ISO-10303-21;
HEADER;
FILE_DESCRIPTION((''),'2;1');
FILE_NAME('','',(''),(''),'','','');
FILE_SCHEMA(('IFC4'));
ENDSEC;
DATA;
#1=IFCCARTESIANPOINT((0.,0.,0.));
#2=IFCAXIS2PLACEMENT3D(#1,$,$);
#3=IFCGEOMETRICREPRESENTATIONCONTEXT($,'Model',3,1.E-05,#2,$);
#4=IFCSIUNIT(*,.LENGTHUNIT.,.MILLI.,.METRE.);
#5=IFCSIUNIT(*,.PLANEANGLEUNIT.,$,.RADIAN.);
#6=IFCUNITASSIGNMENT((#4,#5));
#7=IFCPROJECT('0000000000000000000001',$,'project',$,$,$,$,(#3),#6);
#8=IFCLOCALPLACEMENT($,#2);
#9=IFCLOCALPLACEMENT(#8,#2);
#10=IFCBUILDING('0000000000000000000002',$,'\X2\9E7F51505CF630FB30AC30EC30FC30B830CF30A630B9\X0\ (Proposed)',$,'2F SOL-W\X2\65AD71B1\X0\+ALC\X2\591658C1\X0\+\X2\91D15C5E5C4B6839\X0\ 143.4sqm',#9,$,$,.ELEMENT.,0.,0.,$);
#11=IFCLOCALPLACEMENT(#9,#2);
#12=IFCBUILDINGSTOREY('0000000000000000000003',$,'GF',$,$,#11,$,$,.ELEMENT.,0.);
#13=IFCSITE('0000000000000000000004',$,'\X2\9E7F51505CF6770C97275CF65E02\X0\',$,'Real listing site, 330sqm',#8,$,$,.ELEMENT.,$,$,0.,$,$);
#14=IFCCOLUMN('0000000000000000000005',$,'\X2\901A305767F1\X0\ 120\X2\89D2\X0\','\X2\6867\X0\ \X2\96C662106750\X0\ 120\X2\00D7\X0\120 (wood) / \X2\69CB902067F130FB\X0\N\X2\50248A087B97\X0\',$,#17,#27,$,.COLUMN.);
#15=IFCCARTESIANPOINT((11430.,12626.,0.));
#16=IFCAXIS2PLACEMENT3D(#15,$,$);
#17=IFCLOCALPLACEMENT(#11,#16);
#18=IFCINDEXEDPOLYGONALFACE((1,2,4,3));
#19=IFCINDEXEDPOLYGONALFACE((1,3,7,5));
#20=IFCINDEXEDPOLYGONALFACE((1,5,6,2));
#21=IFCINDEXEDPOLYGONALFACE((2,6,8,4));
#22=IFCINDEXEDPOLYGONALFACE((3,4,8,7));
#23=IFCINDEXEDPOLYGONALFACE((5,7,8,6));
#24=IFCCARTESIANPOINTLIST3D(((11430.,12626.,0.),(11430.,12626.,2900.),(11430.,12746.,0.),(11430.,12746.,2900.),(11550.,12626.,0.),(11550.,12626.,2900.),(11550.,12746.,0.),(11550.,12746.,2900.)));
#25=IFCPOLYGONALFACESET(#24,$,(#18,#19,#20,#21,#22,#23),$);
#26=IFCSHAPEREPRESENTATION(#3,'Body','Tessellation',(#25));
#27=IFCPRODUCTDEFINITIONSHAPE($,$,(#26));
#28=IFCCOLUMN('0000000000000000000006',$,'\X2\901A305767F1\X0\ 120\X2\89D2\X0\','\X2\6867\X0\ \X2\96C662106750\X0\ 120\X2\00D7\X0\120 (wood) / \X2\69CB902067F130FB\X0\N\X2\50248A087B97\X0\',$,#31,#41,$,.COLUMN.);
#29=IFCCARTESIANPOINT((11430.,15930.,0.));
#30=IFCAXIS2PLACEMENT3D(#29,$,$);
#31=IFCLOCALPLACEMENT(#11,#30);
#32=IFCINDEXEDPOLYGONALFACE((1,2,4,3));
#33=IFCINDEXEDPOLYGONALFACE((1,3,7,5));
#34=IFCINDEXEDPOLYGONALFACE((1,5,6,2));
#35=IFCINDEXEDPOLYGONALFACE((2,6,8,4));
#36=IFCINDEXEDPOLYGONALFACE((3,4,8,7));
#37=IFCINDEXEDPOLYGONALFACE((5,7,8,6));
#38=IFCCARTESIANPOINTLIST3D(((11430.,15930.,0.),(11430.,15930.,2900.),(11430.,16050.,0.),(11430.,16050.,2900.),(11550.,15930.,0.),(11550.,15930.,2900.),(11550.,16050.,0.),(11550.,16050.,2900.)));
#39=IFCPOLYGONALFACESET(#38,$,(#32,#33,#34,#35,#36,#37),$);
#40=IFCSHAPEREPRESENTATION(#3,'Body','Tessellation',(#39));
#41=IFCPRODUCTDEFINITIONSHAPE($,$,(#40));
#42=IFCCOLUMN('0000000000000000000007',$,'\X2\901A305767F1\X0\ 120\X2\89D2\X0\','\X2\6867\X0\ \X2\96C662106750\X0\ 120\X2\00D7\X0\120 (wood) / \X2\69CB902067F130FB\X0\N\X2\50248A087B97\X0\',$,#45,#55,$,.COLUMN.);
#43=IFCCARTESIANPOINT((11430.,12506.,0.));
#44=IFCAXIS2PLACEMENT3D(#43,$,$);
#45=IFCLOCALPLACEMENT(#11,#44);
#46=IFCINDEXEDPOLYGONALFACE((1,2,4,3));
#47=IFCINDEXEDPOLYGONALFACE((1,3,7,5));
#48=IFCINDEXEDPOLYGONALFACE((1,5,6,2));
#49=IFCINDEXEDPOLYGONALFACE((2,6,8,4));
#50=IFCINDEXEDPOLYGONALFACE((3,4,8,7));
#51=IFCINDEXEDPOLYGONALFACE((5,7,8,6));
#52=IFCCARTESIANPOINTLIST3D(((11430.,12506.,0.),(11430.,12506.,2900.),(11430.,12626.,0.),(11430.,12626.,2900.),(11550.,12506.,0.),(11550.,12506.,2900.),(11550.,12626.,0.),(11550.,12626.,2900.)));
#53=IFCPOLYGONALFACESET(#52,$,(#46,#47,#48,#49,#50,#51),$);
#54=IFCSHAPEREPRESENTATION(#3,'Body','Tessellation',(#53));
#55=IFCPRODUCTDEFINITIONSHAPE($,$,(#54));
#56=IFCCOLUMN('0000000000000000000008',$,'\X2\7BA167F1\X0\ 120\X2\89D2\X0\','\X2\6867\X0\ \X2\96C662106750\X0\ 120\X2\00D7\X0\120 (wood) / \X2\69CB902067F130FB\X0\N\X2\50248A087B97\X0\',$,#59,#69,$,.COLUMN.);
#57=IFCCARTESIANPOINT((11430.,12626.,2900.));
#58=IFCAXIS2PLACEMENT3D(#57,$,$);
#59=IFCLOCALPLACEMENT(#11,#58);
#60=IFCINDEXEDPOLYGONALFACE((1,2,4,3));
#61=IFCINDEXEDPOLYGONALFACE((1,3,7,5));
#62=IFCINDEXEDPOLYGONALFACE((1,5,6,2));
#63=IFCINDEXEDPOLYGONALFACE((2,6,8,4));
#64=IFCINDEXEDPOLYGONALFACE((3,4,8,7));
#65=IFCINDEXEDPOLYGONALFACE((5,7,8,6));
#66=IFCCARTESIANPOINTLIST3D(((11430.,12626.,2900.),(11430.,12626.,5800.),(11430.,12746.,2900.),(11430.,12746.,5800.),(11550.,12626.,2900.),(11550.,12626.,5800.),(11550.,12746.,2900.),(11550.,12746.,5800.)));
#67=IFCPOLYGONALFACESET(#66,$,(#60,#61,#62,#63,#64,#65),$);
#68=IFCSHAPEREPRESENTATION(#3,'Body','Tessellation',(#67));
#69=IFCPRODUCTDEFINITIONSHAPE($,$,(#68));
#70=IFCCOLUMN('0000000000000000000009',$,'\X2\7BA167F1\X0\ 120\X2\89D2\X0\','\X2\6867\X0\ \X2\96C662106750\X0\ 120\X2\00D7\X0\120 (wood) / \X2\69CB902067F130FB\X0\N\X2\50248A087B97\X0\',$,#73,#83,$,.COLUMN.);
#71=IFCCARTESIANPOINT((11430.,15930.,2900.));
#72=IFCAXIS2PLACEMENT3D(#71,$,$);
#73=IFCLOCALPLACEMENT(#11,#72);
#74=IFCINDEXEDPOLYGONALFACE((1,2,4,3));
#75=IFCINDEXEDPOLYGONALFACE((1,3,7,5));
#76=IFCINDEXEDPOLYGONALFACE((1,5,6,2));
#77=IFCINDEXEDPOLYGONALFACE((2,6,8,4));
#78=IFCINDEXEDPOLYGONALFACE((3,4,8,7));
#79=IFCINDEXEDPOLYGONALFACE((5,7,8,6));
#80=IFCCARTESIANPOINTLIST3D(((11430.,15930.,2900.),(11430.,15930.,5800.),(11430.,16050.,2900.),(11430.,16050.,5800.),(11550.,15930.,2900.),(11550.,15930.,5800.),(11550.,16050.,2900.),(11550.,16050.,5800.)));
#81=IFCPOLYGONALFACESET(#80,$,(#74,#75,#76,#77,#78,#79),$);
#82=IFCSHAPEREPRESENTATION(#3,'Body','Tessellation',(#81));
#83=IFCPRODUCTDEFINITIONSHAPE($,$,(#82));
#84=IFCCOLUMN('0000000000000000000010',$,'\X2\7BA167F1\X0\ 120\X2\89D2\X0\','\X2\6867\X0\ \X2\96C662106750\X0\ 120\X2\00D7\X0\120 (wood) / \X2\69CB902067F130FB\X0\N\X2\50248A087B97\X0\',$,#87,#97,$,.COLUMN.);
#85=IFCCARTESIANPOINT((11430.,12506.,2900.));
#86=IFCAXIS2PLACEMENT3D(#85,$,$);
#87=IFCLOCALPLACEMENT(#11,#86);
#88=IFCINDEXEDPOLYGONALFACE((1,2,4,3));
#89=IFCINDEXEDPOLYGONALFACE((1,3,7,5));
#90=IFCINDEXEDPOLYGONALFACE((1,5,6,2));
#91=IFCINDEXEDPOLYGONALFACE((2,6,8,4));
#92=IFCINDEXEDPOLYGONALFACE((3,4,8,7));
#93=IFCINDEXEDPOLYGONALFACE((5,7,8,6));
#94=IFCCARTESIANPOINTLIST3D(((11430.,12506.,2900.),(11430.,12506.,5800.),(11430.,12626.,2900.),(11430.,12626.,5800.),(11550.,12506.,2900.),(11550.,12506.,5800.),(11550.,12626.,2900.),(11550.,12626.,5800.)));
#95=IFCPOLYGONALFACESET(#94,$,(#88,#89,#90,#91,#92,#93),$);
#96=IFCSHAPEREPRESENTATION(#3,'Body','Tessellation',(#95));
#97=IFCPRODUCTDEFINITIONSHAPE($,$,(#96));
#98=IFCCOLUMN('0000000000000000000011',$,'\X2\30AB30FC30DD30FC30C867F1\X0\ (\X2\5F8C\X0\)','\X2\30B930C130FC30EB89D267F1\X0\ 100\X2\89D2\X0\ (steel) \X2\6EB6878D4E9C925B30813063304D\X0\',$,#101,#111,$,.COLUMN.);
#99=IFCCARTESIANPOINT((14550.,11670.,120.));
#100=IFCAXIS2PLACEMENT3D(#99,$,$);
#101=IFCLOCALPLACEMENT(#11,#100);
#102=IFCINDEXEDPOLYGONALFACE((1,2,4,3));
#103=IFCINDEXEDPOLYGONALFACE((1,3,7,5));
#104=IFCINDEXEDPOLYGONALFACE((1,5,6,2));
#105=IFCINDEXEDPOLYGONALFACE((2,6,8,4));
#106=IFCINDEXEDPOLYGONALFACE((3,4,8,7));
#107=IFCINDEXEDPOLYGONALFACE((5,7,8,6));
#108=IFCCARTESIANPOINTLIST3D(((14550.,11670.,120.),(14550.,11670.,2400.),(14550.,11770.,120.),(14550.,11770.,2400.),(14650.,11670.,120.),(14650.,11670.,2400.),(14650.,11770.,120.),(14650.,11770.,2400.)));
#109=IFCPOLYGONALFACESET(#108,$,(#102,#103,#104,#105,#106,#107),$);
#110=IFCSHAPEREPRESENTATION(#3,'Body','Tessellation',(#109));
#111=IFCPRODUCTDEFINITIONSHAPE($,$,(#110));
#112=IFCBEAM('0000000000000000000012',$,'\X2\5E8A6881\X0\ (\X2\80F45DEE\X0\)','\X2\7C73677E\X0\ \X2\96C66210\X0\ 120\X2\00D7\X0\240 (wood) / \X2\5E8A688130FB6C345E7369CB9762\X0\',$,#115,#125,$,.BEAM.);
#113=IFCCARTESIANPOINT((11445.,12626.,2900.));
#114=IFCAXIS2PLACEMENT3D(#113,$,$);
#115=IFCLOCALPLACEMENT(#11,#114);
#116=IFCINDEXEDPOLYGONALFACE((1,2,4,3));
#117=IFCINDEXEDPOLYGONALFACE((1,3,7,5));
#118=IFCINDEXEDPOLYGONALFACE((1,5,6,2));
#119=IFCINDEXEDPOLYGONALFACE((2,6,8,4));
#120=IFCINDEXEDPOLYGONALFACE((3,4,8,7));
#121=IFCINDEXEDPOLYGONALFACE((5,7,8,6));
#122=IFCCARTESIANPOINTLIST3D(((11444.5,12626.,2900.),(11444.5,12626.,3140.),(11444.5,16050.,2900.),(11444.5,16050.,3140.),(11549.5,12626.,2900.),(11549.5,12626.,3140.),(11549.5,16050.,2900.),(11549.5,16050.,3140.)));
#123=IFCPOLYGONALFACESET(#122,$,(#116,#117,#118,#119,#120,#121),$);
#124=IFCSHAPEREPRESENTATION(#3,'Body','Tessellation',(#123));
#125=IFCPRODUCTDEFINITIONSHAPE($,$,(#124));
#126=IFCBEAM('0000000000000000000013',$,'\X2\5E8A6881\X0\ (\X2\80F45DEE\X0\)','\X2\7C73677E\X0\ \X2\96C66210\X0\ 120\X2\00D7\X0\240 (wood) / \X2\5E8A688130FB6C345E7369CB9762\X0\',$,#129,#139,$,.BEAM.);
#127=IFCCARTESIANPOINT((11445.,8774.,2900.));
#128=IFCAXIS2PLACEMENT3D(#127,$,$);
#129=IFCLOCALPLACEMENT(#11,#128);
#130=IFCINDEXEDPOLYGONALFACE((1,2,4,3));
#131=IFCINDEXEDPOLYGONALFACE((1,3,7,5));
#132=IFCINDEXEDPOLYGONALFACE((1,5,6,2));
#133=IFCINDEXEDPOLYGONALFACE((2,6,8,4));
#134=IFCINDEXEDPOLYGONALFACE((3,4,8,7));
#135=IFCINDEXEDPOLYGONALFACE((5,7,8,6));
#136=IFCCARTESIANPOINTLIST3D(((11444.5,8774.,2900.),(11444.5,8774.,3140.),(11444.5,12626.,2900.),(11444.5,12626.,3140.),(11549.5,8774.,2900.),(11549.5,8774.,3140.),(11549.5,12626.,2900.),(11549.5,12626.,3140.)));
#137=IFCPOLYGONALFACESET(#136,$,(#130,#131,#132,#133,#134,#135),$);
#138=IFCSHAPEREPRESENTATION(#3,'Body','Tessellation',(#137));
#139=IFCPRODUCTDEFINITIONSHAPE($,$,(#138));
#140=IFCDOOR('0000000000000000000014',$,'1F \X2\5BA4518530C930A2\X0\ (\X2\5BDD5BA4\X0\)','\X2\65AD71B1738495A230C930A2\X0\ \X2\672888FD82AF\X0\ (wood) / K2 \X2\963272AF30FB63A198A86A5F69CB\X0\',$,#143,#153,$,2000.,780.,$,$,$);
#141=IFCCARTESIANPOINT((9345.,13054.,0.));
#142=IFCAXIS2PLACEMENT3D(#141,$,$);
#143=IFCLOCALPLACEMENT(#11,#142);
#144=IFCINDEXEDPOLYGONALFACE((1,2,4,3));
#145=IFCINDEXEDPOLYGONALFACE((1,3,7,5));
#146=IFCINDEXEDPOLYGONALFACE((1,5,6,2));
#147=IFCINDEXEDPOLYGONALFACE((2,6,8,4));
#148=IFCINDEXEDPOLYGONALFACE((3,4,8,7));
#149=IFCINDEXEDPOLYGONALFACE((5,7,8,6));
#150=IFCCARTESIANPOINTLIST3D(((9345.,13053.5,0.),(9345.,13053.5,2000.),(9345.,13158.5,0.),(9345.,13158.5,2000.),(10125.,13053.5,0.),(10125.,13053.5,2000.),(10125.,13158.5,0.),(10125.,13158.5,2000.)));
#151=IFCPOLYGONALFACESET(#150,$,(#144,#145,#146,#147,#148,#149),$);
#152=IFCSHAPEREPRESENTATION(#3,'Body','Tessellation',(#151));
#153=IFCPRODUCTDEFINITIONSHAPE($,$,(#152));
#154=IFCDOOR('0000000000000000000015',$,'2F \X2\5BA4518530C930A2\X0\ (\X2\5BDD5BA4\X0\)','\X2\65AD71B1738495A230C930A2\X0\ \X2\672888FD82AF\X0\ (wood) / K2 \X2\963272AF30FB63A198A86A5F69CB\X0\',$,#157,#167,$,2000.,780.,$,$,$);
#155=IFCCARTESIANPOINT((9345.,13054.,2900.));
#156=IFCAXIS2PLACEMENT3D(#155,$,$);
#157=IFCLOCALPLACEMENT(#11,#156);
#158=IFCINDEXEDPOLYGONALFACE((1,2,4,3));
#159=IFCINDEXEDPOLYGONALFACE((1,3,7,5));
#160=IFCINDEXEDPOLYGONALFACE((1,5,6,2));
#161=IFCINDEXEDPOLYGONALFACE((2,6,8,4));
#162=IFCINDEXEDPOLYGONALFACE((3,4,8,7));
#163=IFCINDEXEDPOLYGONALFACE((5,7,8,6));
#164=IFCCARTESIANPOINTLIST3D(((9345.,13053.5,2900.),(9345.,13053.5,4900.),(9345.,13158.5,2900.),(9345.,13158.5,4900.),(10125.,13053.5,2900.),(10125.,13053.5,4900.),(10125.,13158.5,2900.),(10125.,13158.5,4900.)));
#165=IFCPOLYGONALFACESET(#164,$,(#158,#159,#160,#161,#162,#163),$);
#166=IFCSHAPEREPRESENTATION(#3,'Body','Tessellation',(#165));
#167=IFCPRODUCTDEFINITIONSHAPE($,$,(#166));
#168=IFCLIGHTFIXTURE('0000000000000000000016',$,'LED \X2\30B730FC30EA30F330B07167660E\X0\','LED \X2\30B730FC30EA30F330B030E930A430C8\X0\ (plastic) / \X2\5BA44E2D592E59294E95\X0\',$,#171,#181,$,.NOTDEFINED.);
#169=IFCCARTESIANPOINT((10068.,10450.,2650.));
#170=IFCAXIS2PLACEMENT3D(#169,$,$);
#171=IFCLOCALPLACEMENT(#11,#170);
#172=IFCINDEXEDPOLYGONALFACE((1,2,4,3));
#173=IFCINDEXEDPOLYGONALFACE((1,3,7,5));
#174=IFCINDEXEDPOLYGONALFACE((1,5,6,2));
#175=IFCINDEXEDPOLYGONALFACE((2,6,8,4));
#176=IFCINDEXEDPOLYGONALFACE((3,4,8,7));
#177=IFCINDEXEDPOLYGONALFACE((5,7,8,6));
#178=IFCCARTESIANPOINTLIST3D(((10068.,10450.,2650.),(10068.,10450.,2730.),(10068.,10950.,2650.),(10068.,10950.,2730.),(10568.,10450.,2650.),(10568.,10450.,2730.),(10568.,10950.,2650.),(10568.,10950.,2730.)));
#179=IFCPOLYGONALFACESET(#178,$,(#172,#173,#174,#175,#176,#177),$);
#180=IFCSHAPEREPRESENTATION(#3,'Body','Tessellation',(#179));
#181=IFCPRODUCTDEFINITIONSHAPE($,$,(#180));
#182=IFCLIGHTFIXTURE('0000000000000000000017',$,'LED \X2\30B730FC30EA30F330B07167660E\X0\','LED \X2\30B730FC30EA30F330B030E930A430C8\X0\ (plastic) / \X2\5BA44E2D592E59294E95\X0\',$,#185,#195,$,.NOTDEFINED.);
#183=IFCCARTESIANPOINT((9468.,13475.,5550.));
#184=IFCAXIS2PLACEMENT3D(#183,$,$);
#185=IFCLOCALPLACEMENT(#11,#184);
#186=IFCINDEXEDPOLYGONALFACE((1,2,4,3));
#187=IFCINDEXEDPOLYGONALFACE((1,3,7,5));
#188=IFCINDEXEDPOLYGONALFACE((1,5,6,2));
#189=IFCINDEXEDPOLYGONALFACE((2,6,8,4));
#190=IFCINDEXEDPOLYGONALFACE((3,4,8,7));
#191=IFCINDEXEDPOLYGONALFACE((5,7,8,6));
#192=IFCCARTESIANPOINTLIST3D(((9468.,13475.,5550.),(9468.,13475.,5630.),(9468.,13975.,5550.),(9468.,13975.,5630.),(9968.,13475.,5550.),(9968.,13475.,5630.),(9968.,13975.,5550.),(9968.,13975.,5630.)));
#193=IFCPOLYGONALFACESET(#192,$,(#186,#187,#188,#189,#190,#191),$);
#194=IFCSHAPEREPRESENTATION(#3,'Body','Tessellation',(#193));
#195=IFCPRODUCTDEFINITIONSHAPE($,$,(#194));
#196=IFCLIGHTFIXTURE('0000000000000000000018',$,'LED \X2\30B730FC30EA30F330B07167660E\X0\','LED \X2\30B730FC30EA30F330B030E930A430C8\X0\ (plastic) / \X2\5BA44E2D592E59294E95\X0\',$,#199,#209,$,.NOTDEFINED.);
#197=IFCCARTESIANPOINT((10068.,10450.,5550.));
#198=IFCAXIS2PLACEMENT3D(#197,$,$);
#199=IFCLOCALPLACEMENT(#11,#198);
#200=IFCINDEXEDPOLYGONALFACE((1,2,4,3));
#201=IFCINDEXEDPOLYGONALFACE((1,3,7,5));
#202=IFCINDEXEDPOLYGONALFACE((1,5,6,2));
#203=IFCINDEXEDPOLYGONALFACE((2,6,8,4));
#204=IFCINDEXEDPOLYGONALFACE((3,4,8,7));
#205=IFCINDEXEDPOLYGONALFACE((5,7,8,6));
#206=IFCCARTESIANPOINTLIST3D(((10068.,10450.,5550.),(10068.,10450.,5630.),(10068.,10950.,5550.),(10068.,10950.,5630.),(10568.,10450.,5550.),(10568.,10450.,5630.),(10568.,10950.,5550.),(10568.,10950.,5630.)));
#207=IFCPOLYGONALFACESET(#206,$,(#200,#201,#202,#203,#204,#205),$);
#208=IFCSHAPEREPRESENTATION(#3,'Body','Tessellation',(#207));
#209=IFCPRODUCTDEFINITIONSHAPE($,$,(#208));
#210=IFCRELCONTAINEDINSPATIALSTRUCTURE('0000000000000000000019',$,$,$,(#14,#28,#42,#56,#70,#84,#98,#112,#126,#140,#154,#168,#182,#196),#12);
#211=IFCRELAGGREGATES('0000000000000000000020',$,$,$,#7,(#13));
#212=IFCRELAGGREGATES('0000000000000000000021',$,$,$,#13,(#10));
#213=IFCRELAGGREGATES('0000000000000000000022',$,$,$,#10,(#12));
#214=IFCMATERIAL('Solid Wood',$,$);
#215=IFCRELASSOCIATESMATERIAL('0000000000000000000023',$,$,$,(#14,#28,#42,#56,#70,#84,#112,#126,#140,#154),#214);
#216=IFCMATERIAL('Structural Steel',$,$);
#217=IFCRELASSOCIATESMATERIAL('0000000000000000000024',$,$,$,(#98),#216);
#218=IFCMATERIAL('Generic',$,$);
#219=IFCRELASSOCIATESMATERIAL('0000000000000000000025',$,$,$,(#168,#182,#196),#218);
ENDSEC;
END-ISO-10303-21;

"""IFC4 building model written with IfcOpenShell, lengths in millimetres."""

from ifc_helpers import new_model, si_unit, frame, frame_2d, origin, place, context, project, spatial, rectangle, extrude, material, element, save


model = new_model("IFC4")

# Units and contexts
model_context = context("Model", 3, precision=1e-05, world=origin())
ifc_project = project(units=[si_unit("LENGTHUNIT", "METRE", prefix="MILLI"), si_unit("PLANEANGLEUNIT", "RADIAN")], contexts=[model_context])

# Site, building, storey
site_placement = place(None, origin())
site = spatial("IfcSite", under=ifc_project, at=site_placement, Name="鹿児島県霧島市", ObjectType="Real listing site, 330sqm", CompositionType="ELEMENT", RefElevation=0.0)
building_placement = place(site_placement, origin())
building = spatial("IfcBuilding", under=site, at=building_placement, Name="鹿児島・ガレージハウス (Proposed)", ObjectType="2F SOL-W断熱+ALC外壁+金属屋根 143.4sqm", CompositionType="ELEMENT", ElevationOfRefHeight=0.0, ElevationOfTerrain=0.0)
storey_placement = place(building_placement, origin())
storey = spatial("IfcBuildingStorey", under=building, at=storey_placement, Name="GF", CompositionType="ELEMENT", Elevation=0.0)

# Columns
ifc_material_1 = material(Name="Solid Wood")
column_1_placement = place(storey_placement, frame((11430.0, 12626.0, 0.0)))
element("IfcColumn", 1, at=column_1_placement, inside=storey, material=ifc_material_1, Name="通し柱 120角", Description="桧 集成材 120×120 (wood) / 構造柱・N値計算", PredefinedType="COLUMN", context=model_context, shape_type="SweptSolid", body=[
    extrude(rectangle(XDim=120.0, YDim=120.0, at=frame_2d((60.0, 60.0))), frame((11430.0, 12626.0, 0.0)), (0.0, 0.0, 1.0), 2900.0),
])
column_2_placement = place(storey_placement, frame((11430.0, 15930.0, 0.0)))
element("IfcColumn", 2, at=column_2_placement, inside=storey, material=ifc_material_1, Name="通し柱 120角", Description="桧 集成材 120×120 (wood) / 構造柱・N値計算", PredefinedType="COLUMN", context=model_context, shape_type="SweptSolid", body=[
    extrude(rectangle(XDim=120.0, YDim=120.0, at=frame_2d((60.0, 60.0))), frame((11430.0, 15930.0, 0.0)), (0.0, 0.0, 1.0), 2900.0),
])
column_3_placement = place(storey_placement, frame((11430.0, 12506.0, 0.0)))
element("IfcColumn", 3, at=column_3_placement, inside=storey, material=ifc_material_1, Name="通し柱 120角", Description="桧 集成材 120×120 (wood) / 構造柱・N値計算", PredefinedType="COLUMN", context=model_context, shape_type="SweptSolid", body=[
    extrude(rectangle(XDim=120.0, YDim=120.0, at=frame_2d((60.0, 60.0))), frame((11430.0, 12506.0, 0.0)), (0.0, 0.0, 1.0), 2900.0),
])
column_4_placement = place(storey_placement, frame((11430.0, 12626.0, 2900.0)))
element("IfcColumn", 4, at=column_4_placement, inside=storey, material=ifc_material_1, Name="管柱 120角", Description="桧 集成材 120×120 (wood) / 構造柱・N値計算", PredefinedType="COLUMN", context=model_context, shape_type="SweptSolid", body=[
    extrude(rectangle(XDim=120.0, YDim=120.0, at=frame_2d((60.0, 60.0))), frame((11430.0, 12626.0, 2900.0)), (0.0, 0.0, 1.0), 2900.0),
])
column_5_placement = place(storey_placement, frame((11430.0, 15930.0, 2900.0)))
element("IfcColumn", 5, at=column_5_placement, inside=storey, material=ifc_material_1, Name="管柱 120角", Description="桧 集成材 120×120 (wood) / 構造柱・N値計算", PredefinedType="COLUMN", context=model_context, shape_type="SweptSolid", body=[
    extrude(rectangle(XDim=120.0, YDim=120.0, at=frame_2d((60.0, 60.0))), frame((11430.0, 15930.0, 2900.0)), (0.0, 0.0, 1.0), 2900.0),
])
column_6_placement = place(storey_placement, frame((11430.0, 12506.0, 2900.0)))
element("IfcColumn", 6, at=column_6_placement, inside=storey, material=ifc_material_1, Name="管柱 120角", Description="桧 集成材 120×120 (wood) / 構造柱・N値計算", PredefinedType="COLUMN", context=model_context, shape_type="SweptSolid", body=[
    extrude(rectangle(XDim=120.0, YDim=120.0, at=frame_2d((60.0, 60.0))), frame((11430.0, 12506.0, 2900.0)), (0.0, 0.0, 1.0), 2900.0),
])
ifc_material_2 = material(Name="Structural Steel")
column_7_placement = place(storey_placement, frame((14550.0, 11670.0, 120.0)))
element("IfcColumn", 7, at=column_7_placement, inside=storey, material=ifc_material_2, Name="カーポート柱 (後)", Description="スチール角柱 100角 (steel) 溶融亜鉛めっき", PredefinedType="COLUMN", context=model_context, shape_type="SweptSolid", body=[
    extrude(rectangle(XDim=100.0, YDim=100.0, at=frame_2d((50.0, 50.0))), frame((14550.0, 11670.0, 120.0)), (0.0, 0.0, 1.0), 2280.0),
])

# Beams
beam_1_placement = place(storey_placement, frame((11445.0, 12626.0, 2900.0)))
element("IfcBeam", 8, at=beam_1_placement, inside=storey, material=ifc_material_1, Name="床梁 (胴差)", Description="米松 集成 120×240 (wood) / 床梁・水平構面", PredefinedType="BEAM", context=model_context, shape_type="SweptSolid", body=[
    extrude(rectangle(XDim=105.0, YDim=3424.0, at=frame_2d((52.0, 1712.0))), frame((11445.0, 12626.0, 2900.0)), (0.0, 0.0, 1.0), 240.0),
])
beam_2_placement = place(storey_placement, frame((11445.0, 8774.0, 2900.0)))
element("IfcBeam", 9, at=beam_2_placement, inside=storey, material=ifc_material_1, Name="床梁 (胴差)", Description="米松 集成 120×240 (wood) / 床梁・水平構面", PredefinedType="BEAM", context=model_context, shape_type="SweptSolid", body=[
    extrude(rectangle(XDim=105.0, YDim=3852.0, at=frame_2d((52.0, 1926.0))), frame((11445.0, 8774.0, 2900.0)), (0.0, 0.0, 1.0), 240.0),
])

# Doors
door_1_placement = place(storey_placement, frame((9345.0, 13054.0, 0.0)))
element("IfcDoor", 10, at=door_1_placement, inside=storey, material=ifc_material_1, Name="1F 室内ドア (寝室)", Description="断熱玄関ドア 木製芯 (wood) / K2 防犯・採風機構", OverallHeight=2000.0, OverallWidth=780.0, context=model_context, shape_type="SweptSolid", body=[
    extrude(rectangle(XDim=780.0, YDim=105.0, at=frame_2d((390.0, 52.0))), frame((9345.0, 13054.0, 0.0)), (0.0, 0.0, 1.0), 2000.0),
])
door_2_placement = place(storey_placement, frame((9345.0, 13054.0, 2900.0)))
element("IfcDoor", 11, at=door_2_placement, inside=storey, material=ifc_material_1, Name="2F 室内ドア (寝室)", Description="断熱玄関ドア 木製芯 (wood) / K2 防犯・採風機構", OverallHeight=2000.0, OverallWidth=780.0, context=model_context, shape_type="SweptSolid", body=[
    extrude(rectangle(XDim=780.0, YDim=105.0, at=frame_2d((390.0, 52.0))), frame((9345.0, 13054.0, 2900.0)), (0.0, 0.0, 1.0), 2000.0),
])

# Light fixtures
ifc_material_3 = material(Name="Generic")
light_fixture_1_placement = place(storey_placement, frame((10068.0, 10450.0, 2650.0)))
element("IfcLightFixture", 12, at=light_fixture_1_placement, inside=storey, material=ifc_material_3, Name="LED シーリング照明", Description="LED シーリングライト (plastic) / 室中央天井", PredefinedType="NOTDEFINED", context=model_context, shape_type="SweptSolid", body=[
    extrude(rectangle(XDim=500.0, YDim=500.0, at=frame_2d((250.0, 250.0))), frame((10068.0, 10450.0, 2650.0)), (0.0, 0.0, 1.0), 80.0),
])
light_fixture_2_placement = place(storey_placement, frame((9468.0, 13475.0, 5550.0)))
element("IfcLightFixture", 13, at=light_fixture_2_placement, inside=storey, material=ifc_material_3, Name="LED シーリング照明", Description="LED シーリングライト (plastic) / 室中央天井", PredefinedType="NOTDEFINED", context=model_context, shape_type="SweptSolid", body=[
    extrude(rectangle(XDim=500.0, YDim=500.0, at=frame_2d((250.0, 250.0))), frame((9468.0, 13475.0, 5550.0)), (0.0, 0.0, 1.0), 80.0),
])
light_fixture_3_placement = place(storey_placement, frame((10068.0, 10450.0, 5550.0)))
element("IfcLightFixture", 14, at=light_fixture_3_placement, inside=storey, material=ifc_material_3, Name="LED シーリング照明", Description="LED シーリングライト (plastic) / 室中央天井", PredefinedType="NOTDEFINED", context=model_context, shape_type="SweptSolid", body=[
    extrude(rectangle(XDim=500.0, YDim=500.0, at=frame_2d((250.0, 250.0))), frame((10068.0, 10450.0, 5550.0)), (0.0, 0.0, 1.0), 80.0),
])

save(model, "model.ifc")
